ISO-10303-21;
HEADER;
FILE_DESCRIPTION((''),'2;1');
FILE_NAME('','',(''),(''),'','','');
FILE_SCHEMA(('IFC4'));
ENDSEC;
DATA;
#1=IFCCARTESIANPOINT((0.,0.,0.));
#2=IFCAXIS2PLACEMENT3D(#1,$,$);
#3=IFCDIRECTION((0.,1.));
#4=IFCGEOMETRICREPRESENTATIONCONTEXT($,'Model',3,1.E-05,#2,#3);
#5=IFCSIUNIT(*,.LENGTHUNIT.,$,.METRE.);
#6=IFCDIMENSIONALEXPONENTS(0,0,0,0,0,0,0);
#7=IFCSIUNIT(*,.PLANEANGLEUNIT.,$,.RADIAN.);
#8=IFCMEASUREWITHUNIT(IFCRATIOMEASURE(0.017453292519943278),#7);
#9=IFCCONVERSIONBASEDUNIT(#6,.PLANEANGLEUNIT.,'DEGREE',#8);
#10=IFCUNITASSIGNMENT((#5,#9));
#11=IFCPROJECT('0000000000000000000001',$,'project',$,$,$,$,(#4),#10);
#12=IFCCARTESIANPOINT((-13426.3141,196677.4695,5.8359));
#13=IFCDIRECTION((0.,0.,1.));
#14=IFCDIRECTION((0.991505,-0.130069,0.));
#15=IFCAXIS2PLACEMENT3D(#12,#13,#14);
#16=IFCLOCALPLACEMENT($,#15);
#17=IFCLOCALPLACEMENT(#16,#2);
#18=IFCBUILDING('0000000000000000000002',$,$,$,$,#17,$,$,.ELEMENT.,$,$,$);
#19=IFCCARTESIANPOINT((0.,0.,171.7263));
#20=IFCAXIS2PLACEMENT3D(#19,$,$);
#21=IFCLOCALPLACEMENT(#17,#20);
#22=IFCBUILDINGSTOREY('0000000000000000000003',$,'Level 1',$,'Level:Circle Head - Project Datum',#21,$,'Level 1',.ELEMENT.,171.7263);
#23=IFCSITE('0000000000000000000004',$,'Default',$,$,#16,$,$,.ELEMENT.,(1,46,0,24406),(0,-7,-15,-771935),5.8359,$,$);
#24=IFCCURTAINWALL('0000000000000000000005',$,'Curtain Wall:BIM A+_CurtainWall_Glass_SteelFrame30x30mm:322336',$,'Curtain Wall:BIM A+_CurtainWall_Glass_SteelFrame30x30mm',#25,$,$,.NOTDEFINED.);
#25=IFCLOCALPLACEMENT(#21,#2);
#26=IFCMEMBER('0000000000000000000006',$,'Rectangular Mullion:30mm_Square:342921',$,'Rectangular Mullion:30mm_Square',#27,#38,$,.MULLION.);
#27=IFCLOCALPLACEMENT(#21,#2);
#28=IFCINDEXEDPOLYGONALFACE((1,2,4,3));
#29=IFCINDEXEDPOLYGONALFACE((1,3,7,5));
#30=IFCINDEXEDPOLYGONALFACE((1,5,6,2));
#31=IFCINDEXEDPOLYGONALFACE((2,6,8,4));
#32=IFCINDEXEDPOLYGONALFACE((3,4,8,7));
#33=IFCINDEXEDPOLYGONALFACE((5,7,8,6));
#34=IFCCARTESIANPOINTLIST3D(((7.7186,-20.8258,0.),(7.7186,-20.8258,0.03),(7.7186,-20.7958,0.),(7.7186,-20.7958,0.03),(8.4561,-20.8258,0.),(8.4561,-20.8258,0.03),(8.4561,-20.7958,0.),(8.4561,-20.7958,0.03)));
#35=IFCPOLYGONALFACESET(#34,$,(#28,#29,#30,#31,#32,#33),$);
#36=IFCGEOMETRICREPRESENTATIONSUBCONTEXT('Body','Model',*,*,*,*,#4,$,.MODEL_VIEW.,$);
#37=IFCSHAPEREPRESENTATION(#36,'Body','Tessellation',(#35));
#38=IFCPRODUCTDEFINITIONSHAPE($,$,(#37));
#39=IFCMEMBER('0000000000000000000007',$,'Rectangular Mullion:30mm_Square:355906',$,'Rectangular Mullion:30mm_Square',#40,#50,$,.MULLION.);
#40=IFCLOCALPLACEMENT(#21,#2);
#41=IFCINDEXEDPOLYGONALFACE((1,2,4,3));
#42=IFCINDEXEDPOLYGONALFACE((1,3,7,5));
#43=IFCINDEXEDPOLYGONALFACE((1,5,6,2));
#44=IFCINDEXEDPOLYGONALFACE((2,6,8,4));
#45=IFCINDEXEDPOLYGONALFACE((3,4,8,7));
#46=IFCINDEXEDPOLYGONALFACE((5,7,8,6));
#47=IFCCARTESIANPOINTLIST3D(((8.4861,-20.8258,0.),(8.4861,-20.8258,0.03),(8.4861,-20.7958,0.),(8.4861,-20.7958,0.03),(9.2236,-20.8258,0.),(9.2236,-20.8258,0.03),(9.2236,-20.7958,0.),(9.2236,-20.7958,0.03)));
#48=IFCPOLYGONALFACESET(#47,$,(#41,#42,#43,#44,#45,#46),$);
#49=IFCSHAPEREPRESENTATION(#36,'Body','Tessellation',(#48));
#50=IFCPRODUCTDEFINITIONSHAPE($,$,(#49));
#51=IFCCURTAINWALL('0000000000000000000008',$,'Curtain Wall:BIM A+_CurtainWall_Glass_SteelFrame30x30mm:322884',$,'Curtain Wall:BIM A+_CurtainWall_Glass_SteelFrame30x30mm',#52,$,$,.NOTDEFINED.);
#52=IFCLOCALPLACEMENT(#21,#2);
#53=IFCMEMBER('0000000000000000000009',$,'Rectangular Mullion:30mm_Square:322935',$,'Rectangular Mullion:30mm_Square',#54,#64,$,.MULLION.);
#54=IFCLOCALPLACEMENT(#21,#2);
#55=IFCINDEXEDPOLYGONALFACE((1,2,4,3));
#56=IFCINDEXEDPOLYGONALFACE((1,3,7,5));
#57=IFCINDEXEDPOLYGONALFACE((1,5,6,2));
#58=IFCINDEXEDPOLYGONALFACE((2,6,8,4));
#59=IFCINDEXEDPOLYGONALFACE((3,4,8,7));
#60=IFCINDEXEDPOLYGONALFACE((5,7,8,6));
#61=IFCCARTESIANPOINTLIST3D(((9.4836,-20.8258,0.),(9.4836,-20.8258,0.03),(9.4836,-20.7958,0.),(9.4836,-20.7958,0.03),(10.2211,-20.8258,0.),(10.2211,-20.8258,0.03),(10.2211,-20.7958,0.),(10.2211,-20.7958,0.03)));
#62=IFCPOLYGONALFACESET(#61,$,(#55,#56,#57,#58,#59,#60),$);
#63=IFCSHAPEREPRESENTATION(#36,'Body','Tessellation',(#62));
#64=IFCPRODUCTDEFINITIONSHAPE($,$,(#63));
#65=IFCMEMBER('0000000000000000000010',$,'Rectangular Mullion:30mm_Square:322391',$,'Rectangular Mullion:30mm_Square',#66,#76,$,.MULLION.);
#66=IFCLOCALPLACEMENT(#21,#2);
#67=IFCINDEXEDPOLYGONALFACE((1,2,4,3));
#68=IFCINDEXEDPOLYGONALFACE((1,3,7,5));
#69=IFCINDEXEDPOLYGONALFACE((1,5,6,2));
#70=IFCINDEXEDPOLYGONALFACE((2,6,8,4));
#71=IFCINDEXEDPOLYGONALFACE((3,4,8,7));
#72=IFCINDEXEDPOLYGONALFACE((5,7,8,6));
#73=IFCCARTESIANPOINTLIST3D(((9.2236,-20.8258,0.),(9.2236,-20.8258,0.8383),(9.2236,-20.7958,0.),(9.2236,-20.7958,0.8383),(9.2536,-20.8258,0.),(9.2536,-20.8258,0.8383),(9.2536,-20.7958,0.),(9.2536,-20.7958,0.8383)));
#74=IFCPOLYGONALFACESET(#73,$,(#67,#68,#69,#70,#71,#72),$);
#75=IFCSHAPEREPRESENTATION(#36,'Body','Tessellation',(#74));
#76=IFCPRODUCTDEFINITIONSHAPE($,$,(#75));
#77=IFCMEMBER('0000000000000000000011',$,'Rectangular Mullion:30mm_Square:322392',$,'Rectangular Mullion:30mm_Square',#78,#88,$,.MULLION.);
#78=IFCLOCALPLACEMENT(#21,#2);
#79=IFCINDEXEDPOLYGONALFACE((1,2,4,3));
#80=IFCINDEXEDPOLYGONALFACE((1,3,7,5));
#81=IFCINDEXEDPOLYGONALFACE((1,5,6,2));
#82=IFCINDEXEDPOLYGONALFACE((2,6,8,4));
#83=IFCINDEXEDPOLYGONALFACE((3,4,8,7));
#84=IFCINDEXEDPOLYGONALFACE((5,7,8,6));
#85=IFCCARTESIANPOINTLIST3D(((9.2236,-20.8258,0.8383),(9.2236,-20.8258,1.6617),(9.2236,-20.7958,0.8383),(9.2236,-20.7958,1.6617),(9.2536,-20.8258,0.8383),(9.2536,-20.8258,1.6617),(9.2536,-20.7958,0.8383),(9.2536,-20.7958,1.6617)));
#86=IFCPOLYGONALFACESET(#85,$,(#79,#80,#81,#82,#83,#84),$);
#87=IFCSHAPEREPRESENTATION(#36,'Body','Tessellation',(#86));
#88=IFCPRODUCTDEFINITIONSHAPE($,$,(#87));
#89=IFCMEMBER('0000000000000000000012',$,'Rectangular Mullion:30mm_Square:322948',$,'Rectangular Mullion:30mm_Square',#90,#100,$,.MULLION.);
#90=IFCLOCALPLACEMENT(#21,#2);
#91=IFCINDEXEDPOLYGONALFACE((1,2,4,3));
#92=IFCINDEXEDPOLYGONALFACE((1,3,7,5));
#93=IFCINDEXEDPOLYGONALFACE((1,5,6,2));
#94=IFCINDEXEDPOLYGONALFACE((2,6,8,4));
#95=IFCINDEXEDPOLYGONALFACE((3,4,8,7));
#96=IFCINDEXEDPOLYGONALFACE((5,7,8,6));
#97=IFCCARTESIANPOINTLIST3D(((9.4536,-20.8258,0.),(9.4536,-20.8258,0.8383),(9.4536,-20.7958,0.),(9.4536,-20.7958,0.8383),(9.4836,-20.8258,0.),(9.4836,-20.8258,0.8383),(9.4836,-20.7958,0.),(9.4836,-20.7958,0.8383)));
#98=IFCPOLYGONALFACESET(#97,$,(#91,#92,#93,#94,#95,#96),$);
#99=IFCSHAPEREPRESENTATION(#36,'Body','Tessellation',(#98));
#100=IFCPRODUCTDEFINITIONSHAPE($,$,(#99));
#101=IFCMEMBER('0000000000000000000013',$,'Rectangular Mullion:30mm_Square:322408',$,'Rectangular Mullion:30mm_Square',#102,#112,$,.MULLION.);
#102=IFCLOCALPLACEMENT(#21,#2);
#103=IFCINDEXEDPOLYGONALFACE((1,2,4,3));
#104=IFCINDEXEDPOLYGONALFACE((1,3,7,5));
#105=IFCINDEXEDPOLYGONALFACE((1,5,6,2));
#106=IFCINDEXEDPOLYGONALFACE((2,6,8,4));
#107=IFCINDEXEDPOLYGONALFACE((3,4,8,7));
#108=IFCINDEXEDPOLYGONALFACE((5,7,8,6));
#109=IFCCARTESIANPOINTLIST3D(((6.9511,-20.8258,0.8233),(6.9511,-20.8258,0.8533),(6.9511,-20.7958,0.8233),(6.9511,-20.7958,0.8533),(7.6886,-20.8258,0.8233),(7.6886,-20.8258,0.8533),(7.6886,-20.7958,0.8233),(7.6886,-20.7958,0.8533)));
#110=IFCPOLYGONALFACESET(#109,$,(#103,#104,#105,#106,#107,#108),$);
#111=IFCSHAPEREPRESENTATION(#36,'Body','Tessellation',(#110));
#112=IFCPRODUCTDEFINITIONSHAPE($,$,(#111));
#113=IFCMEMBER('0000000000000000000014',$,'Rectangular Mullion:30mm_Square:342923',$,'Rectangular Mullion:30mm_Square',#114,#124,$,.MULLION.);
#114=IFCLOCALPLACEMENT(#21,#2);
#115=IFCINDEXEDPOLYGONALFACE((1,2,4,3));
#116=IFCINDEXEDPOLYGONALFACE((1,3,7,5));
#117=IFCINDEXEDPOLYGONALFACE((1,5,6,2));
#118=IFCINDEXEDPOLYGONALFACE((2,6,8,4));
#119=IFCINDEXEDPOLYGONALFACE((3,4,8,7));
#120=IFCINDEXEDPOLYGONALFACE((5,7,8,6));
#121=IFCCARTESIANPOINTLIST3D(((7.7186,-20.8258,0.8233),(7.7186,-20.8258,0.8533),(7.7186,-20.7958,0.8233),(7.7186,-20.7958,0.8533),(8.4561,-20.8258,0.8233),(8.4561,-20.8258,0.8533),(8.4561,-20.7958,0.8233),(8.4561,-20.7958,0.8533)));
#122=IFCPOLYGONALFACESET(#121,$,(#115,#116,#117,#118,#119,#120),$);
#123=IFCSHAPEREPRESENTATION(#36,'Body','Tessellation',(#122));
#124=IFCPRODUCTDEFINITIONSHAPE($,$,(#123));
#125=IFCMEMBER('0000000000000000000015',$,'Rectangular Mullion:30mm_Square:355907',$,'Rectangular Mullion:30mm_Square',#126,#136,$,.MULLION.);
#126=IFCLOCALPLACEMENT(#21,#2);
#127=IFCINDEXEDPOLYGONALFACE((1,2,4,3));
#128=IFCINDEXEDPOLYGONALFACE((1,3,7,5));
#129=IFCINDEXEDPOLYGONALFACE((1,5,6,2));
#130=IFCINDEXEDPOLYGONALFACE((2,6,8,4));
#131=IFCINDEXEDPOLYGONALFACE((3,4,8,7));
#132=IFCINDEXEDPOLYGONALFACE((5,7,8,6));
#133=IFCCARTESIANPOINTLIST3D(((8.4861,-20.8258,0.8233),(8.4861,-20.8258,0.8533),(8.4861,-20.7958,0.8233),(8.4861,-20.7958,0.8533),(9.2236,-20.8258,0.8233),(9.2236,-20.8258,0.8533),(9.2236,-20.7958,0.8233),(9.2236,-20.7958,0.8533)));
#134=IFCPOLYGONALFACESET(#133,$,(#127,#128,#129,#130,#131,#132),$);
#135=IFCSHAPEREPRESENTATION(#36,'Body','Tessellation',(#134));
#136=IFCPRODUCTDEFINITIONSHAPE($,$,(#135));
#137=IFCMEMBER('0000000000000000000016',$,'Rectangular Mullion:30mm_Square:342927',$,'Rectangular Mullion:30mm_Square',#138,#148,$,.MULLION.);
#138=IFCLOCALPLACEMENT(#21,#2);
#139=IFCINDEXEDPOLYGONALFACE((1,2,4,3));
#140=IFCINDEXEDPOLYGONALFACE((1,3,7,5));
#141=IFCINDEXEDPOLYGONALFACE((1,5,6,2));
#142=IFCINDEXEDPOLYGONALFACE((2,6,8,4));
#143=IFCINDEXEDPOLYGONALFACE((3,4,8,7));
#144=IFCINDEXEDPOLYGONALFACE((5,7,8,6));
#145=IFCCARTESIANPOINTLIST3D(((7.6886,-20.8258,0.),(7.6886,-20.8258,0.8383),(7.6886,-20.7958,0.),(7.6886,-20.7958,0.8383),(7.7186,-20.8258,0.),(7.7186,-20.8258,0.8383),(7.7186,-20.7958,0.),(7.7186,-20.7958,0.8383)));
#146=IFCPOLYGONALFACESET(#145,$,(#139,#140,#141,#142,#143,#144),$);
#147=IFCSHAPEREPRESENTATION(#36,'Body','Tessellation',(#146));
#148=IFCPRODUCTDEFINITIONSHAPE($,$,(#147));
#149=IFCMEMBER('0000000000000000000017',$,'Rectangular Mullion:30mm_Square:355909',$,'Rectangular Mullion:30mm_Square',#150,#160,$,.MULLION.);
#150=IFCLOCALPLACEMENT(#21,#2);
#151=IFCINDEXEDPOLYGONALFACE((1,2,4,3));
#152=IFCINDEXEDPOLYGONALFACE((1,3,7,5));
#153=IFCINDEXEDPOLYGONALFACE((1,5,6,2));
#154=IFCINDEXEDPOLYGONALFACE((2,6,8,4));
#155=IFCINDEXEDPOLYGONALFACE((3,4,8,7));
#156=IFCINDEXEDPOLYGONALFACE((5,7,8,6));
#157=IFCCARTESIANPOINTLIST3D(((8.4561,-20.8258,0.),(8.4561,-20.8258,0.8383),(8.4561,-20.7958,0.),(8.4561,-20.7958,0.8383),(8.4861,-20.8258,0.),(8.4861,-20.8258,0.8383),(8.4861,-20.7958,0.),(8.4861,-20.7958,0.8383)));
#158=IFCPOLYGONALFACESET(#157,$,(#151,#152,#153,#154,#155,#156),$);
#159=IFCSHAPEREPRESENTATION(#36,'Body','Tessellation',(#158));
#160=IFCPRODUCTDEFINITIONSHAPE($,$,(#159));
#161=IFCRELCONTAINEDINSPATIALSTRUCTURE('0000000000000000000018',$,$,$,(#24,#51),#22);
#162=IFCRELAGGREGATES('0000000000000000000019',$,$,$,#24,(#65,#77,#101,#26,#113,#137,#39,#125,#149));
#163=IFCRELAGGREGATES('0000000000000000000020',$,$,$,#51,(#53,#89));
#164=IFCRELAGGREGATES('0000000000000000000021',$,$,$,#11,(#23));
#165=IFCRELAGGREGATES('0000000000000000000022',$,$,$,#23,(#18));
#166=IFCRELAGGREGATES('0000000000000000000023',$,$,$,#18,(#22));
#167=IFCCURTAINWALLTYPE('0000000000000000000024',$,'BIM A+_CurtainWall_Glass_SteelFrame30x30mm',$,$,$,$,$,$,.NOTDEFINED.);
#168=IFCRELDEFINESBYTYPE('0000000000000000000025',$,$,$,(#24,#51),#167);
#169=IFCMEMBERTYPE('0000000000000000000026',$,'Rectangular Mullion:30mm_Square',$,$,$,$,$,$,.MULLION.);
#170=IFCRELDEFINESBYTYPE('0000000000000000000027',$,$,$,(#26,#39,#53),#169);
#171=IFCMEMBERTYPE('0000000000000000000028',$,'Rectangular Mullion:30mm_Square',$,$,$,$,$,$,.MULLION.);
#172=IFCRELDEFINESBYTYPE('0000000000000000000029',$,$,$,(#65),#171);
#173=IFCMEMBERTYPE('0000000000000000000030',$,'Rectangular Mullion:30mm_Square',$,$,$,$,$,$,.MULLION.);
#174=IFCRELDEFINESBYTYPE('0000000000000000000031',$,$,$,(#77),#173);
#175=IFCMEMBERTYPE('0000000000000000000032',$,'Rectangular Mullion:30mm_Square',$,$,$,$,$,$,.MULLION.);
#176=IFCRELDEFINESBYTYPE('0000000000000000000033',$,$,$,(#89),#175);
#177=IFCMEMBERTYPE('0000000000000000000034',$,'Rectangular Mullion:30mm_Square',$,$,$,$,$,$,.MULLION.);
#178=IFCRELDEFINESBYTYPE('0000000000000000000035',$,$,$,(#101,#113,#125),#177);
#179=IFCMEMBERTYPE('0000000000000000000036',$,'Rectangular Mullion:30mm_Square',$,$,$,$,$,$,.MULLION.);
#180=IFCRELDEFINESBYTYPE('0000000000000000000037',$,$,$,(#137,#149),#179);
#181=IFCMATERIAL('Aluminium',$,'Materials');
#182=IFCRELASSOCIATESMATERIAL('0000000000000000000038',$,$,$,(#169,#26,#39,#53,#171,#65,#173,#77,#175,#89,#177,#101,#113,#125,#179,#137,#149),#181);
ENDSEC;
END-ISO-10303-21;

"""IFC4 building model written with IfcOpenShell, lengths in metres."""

from ifc_helpers import new_model, entity, si_unit, converted_unit, direction, frame, origin, place, context, subcontext, project, spatial, indexed_curve, outline, extrude, source, transform, mapped, material, type_object, type_shapes, element, aggregate, save


model = new_model("IFC4")

# Units and contexts
model_context = context("Model", 3, precision=1e-05, world=origin(), true_north=direction((0.0, 1.0)))
body_context = subcontext(model_context, "Body", "Model", "MODEL_VIEW")
ifc_project = project(units=[si_unit("LENGTHUNIT", "METRE"), converted_unit("PLANEANGLEUNIT", "DEGREE", entity("IfcRatioMeasure", 0.017453292519943278), si_unit("PLANEANGLEUNIT", "RADIAN"), dimensions=[0, 0, 0, 0, 0, 0, 0])], contexts=[model_context])

# Site, building, storey
site_placement = place(None, frame((-13426.3141, 196677.4695, 5.8359), z_axis=(0.0, 0.0, 1.0), x_axis=(0.991505, -0.130069, 0.0)))
site = spatial("IfcSite", under=ifc_project, at=site_placement, Name="Default", CompositionType="ELEMENT", RefLatitude=(1, 46, 0, 24406), RefLongitude=(0, -7, -15, -771935), RefElevation=5.8359)
building_placement = place(site_placement, origin())
building = spatial("IfcBuilding", under=site, at=building_placement, CompositionType="ELEMENT")
storey_placement = place(building_placement, frame((0.0, 0.0, 171.7263)))
storey = spatial("IfcBuildingStorey", under=building, at=storey_placement, Name="Level 1", ObjectType="Level:Circle Head - Project Datum", LongName="Level 1", CompositionType="ELEMENT", Elevation=171.7263)

# Curtain wall, members
curtain_wall_type_1 = type_object("IfcCurtainWallType", Name="BIM A+_CurtainWall_Glass_SteelFrame30x30mm", PredefinedType="NOTDEFINED")
curtain_wall_1_placement = place(storey_placement, frame((0.0, 0.0, -171.7263)))
curtain_wall_1 = element("IfcCurtainWall", 1, at=curtain_wall_1_placement, inside=storey, type_object=curtain_wall_type_1, Name="Curtain Wall:BIM A+_CurtainWall_Glass_SteelFrame30x30mm:322336", ObjectType="Curtain Wall:BIM A+_CurtainWall_Glass_SteelFrame30x30mm", PredefinedType="NOTDEFINED")
ifc_material_1 = material(Name="Aluminium", Category="Materials")
member_type_1 = type_object("IfcMemberType", Name="Rectangular Mullion:30mm_Square", PredefinedType="MULLION", material=ifc_material_1)
shared_shape_1 = source(origin(), body_context, "Body", "SweptSolid", [
    extrude(outline(indexed_curve([(-0.015, -0.015), (0.015, -0.015), (0.015, 0.015), (-0.015, 0.015), (-0.015, -0.015)], self_intersect=False)), frame((-0.015, 0.0, -0.7375), z_axis=(0.0, 0.0, 1.0), x_axis=(0.0, -1.0, 0.0)), (0.0, 0.0, 1.0), 0.7375),
])
type_shapes(member_type_1, [shared_shape_1])
member_1_placement = place(curtain_wall_1_placement, frame((7.7186, -20.8108, 171.7263), z_axis=(-1.0, 0.0, 0.0), x_axis=(0.0, 0.0, -1.0)))
member_1 = element("IfcMember", 2, at=member_1_placement, type_object=member_type_1, material=ifc_material_1, Name="Rectangular Mullion:30mm_Square:342921", ObjectType="Rectangular Mullion:30mm_Square", PredefinedType="MULLION", context=body_context, shape_type="MappedRepresentation", body=[
    mapped(shared_shape_1, transform((0.0, 0.0, 0.0), scale=1.0)),
])
member_2_placement = place(curtain_wall_1_placement, frame((8.4861, -20.8108, 171.7263), z_axis=(-1.0, 0.0, 0.0), x_axis=(0.0, 0.0, -1.0)))
member_2 = element("IfcMember", 3, at=member_2_placement, type_object=member_type_1, material=ifc_material_1, Name="Rectangular Mullion:30mm_Square:355906", ObjectType="Rectangular Mullion:30mm_Square", PredefinedType="MULLION", context=body_context, shape_type="MappedRepresentation", body=[
    mapped(shared_shape_1, transform((0.0, 0.0, 0.0), scale=1.0)),
])

# Curtain wall, member
curtain_wall_2_placement = place(storey_placement, frame((0.0, 0.0, -171.7263)))
curtain_wall_2 = element("IfcCurtainWall", 4, at=curtain_wall_2_placement, inside=storey, type_object=curtain_wall_type_1, Name="Curtain Wall:BIM A+_CurtainWall_Glass_SteelFrame30x30mm:322884", ObjectType="Curtain Wall:BIM A+_CurtainWall_Glass_SteelFrame30x30mm", PredefinedType="NOTDEFINED")
member_3_placement = place(curtain_wall_2_placement, frame((9.4836, -20.8108, 171.7263), z_axis=(-1.0, 0.0, 0.0), x_axis=(0.0, 0.0, -1.0)))
member_3 = element("IfcMember", 5, at=member_3_placement, type_object=member_type_1, material=ifc_material_1, Name="Rectangular Mullion:30mm_Square:322935", ObjectType="Rectangular Mullion:30mm_Square", PredefinedType="MULLION", context=body_context, shape_type="MappedRepresentation", body=[
    mapped(shared_shape_1, transform((0.0, 0.0, 0.0), scale=1.0)),
])

# Members
member_type_2 = type_object("IfcMemberType", Name="Rectangular Mullion:30mm_Square", PredefinedType="MULLION", material=ifc_material_1)
shared_shape_2 = source(origin(), body_context, "Body", "SweptSolid", [
    extrude(outline(indexed_curve([(-0.015, -0.015), (0.015, -0.015), (0.015, 0.015), (-0.015, 0.015), (-0.015, -0.015)], self_intersect=False)), frame((-0.015, 0.0, -0.8383), z_axis=(0.0, 0.0, 1.0), x_axis=(0.0, -1.0, 0.0)), (0.0, 0.0, 1.0), 0.8383),
])
type_shapes(member_type_2, [shared_shape_2])
member_4_placement = place(curtain_wall_1_placement, frame((9.2536, -20.8108, 171.7263), z_axis=(0.0, 0.0, -1.0), x_axis=(1.0, 0.0, 0.0)))
member_4 = element("IfcMember", 6, at=member_4_placement, type_object=member_type_2, material=ifc_material_1, Name="Rectangular Mullion:30mm_Square:322391", ObjectType="Rectangular Mullion:30mm_Square", PredefinedType="MULLION", context=body_context, shape_type="MappedRepresentation", body=[
    mapped(shared_shape_2, transform((0.0, 0.0, 0.0), scale=1.0)),
])
member_type_3 = type_object("IfcMemberType", Name="Rectangular Mullion:30mm_Square", PredefinedType="MULLION", material=ifc_material_1)
shared_shape_3 = source(origin(), body_context, "Body", "SweptSolid", [
    extrude(outline(indexed_curve([(-0.015, -0.015), (0.015, -0.015), (0.015, 0.015), (-0.015, 0.015), (-0.015, -0.015)], self_intersect=False)), frame((-0.015, 0.0, -0.8233), z_axis=(0.0, 0.0, 1.0), x_axis=(0.0, -1.0, 0.0)), (0.0, 0.0, 1.0), 0.8233),
])
type_shapes(member_type_3, [shared_shape_3])
member_5_placement = place(curtain_wall_1_placement, frame((9.2536, -20.8108, 172.5646), z_axis=(0.0, 0.0, -1.0), x_axis=(1.0, 0.0, 0.0)))
member_5 = element("IfcMember", 7, at=member_5_placement, type_object=member_type_3, material=ifc_material_1, Name="Rectangular Mullion:30mm_Square:322392", ObjectType="Rectangular Mullion:30mm_Square", PredefinedType="MULLION", context=body_context, shape_type="MappedRepresentation", body=[
    mapped(shared_shape_3, transform((0.0, 0.0, 0.0), scale=1.0)),
])
member_type_4 = type_object("IfcMemberType", Name="Rectangular Mullion:30mm_Square", PredefinedType="MULLION", material=ifc_material_1)
shared_shape_4 = source(origin(), body_context, "Body", "SweptSolid", [
    extrude(outline(indexed_curve([(-0.015, -0.015), (0.015, -0.015), (0.015, 0.015), (-0.015, 0.015), (-0.015, -0.015)], self_intersect=False)), frame((-0.015, 0.0, -0.8383), z_axis=(0.0, 0.0, 1.0), x_axis=(0.0, -1.0, 0.0)), (0.0, 0.0, 1.0), 0.8383),
])
type_shapes(member_type_4, [shared_shape_4])
member_6_placement = place(curtain_wall_2_placement, frame((9.4536, -20.8108, 172.5646), z_axis=(0.0, 0.0, 1.0), x_axis=(-1.0, 0.0, 0.0)))
member_6 = element("IfcMember", 8, at=member_6_placement, type_object=member_type_4, material=ifc_material_1, Name="Rectangular Mullion:30mm_Square:322948", ObjectType="Rectangular Mullion:30mm_Square", PredefinedType="MULLION", context=body_context, shape_type="MappedRepresentation", body=[
    mapped(shared_shape_4, transform((0.0, 0.0, 0.0), scale=1.0)),
])
member_type_5 = type_object("IfcMemberType", Name="Rectangular Mullion:30mm_Square", PredefinedType="MULLION", material=ifc_material_1)
shared_shape_5 = source(origin(), body_context, "Body", "SweptSolid", [
    extrude(outline(indexed_curve([(-0.015, -0.015), (0.015, -0.015), (0.015, 0.015), (-0.015, 0.015), (-0.015, -0.015)], self_intersect=False)), frame((0.0, 0.0, -0.7375), z_axis=(0.0, 0.0, 1.0), x_axis=(0.0, -1.0, 0.0)), (0.0, 0.0, 1.0), 0.7375),
])
type_shapes(member_type_5, [shared_shape_5])
member_7_placement = place(curtain_wall_1_placement, frame((7.6886, -20.8108, 172.5646), z_axis=(1.0, 0.0, 0.0), x_axis=(0.0, 0.0, 1.0)))
member_7 = element("IfcMember", 9, at=member_7_placement, type_object=member_type_5, material=ifc_material_1, Name="Rectangular Mullion:30mm_Square:322408", ObjectType="Rectangular Mullion:30mm_Square", PredefinedType="MULLION", context=body_context, shape_type="MappedRepresentation", body=[
    mapped(shared_shape_5, transform((0.0, 0.0, 0.0), scale=1.0)),
])
member_8_placement = place(curtain_wall_1_placement, frame((8.4561, -20.8108, 172.5646), z_axis=(1.0, 0.0, 0.0), x_axis=(0.0, 0.0, 1.0)))
member_8 = element("IfcMember", 10, at=member_8_placement, type_object=member_type_5, material=ifc_material_1, Name="Rectangular Mullion:30mm_Square:342923", ObjectType="Rectangular Mullion:30mm_Square", PredefinedType="MULLION", context=body_context, shape_type="MappedRepresentation", body=[
    mapped(shared_shape_5, transform((0.0, 0.0, 0.0), scale=1.0)),
])
member_9_placement = place(curtain_wall_1_placement, frame((9.2236, -20.8108, 172.5646), z_axis=(1.0, 0.0, 0.0), x_axis=(0.0, 0.0, 1.0)))
member_9 = element("IfcMember", 11, at=member_9_placement, type_object=member_type_5, material=ifc_material_1, Name="Rectangular Mullion:30mm_Square:355907", ObjectType="Rectangular Mullion:30mm_Square", PredefinedType="MULLION", context=body_context, shape_type="MappedRepresentation", body=[
    mapped(shared_shape_5, transform((0.0, 0.0, 0.0), scale=1.0)),
])
member_type_6 = type_object("IfcMemberType", Name="Rectangular Mullion:30mm_Square", PredefinedType="MULLION", material=ifc_material_1)
shared_shape_6 = source(origin(), body_context, "Body", "SweptSolid", [
    extrude(outline(indexed_curve([(-0.015, -0.015), (0.015, -0.015), (0.015, 0.015), (-0.015, 0.015), (-0.015, -0.015)], self_intersect=False)), frame((0.0, 0.0, -0.8383), z_axis=(0.0, 0.0, 1.0), x_axis=(0.0, -1.0, 0.0)), (0.0, 0.0, 1.0), 0.8383),
])
type_shapes(member_type_6, [shared_shape_6])
member_10_placement = place(curtain_wall_1_placement, frame((7.7036, -20.8108, 171.7263), z_axis=(0.0, 0.0, -1.0), x_axis=(1.0, 0.0, 0.0)))
member_10 = element("IfcMember", 12, at=member_10_placement, type_object=member_type_6, material=ifc_material_1, Name="Rectangular Mullion:30mm_Square:342927", ObjectType="Rectangular Mullion:30mm_Square", PredefinedType="MULLION", context=body_context, shape_type="MappedRepresentation", body=[
    mapped(shared_shape_6, transform((0.0, 0.0, 0.0), scale=1.0)),
])
member_11_placement = place(curtain_wall_1_placement, frame((8.4711, -20.8108, 171.7263), z_axis=(0.0, 0.0, -1.0), x_axis=(1.0, 0.0, 0.0)))
member_11 = element("IfcMember", 13, at=member_11_placement, type_object=member_type_6, material=ifc_material_1, Name="Rectangular Mullion:30mm_Square:355909", ObjectType="Rectangular Mullion:30mm_Square", PredefinedType="MULLION", context=body_context, shape_type="MappedRepresentation", body=[
    mapped(shared_shape_6, transform((0.0, 0.0, 0.0), scale=1.0)),
])

aggregate(curtain_wall_1, [member_4, member_5, member_7, member_1, member_8, member_10, member_2, member_9, member_11])
aggregate(curtain_wall_2, [member_3, member_6])

save(model, "model.ifc")
